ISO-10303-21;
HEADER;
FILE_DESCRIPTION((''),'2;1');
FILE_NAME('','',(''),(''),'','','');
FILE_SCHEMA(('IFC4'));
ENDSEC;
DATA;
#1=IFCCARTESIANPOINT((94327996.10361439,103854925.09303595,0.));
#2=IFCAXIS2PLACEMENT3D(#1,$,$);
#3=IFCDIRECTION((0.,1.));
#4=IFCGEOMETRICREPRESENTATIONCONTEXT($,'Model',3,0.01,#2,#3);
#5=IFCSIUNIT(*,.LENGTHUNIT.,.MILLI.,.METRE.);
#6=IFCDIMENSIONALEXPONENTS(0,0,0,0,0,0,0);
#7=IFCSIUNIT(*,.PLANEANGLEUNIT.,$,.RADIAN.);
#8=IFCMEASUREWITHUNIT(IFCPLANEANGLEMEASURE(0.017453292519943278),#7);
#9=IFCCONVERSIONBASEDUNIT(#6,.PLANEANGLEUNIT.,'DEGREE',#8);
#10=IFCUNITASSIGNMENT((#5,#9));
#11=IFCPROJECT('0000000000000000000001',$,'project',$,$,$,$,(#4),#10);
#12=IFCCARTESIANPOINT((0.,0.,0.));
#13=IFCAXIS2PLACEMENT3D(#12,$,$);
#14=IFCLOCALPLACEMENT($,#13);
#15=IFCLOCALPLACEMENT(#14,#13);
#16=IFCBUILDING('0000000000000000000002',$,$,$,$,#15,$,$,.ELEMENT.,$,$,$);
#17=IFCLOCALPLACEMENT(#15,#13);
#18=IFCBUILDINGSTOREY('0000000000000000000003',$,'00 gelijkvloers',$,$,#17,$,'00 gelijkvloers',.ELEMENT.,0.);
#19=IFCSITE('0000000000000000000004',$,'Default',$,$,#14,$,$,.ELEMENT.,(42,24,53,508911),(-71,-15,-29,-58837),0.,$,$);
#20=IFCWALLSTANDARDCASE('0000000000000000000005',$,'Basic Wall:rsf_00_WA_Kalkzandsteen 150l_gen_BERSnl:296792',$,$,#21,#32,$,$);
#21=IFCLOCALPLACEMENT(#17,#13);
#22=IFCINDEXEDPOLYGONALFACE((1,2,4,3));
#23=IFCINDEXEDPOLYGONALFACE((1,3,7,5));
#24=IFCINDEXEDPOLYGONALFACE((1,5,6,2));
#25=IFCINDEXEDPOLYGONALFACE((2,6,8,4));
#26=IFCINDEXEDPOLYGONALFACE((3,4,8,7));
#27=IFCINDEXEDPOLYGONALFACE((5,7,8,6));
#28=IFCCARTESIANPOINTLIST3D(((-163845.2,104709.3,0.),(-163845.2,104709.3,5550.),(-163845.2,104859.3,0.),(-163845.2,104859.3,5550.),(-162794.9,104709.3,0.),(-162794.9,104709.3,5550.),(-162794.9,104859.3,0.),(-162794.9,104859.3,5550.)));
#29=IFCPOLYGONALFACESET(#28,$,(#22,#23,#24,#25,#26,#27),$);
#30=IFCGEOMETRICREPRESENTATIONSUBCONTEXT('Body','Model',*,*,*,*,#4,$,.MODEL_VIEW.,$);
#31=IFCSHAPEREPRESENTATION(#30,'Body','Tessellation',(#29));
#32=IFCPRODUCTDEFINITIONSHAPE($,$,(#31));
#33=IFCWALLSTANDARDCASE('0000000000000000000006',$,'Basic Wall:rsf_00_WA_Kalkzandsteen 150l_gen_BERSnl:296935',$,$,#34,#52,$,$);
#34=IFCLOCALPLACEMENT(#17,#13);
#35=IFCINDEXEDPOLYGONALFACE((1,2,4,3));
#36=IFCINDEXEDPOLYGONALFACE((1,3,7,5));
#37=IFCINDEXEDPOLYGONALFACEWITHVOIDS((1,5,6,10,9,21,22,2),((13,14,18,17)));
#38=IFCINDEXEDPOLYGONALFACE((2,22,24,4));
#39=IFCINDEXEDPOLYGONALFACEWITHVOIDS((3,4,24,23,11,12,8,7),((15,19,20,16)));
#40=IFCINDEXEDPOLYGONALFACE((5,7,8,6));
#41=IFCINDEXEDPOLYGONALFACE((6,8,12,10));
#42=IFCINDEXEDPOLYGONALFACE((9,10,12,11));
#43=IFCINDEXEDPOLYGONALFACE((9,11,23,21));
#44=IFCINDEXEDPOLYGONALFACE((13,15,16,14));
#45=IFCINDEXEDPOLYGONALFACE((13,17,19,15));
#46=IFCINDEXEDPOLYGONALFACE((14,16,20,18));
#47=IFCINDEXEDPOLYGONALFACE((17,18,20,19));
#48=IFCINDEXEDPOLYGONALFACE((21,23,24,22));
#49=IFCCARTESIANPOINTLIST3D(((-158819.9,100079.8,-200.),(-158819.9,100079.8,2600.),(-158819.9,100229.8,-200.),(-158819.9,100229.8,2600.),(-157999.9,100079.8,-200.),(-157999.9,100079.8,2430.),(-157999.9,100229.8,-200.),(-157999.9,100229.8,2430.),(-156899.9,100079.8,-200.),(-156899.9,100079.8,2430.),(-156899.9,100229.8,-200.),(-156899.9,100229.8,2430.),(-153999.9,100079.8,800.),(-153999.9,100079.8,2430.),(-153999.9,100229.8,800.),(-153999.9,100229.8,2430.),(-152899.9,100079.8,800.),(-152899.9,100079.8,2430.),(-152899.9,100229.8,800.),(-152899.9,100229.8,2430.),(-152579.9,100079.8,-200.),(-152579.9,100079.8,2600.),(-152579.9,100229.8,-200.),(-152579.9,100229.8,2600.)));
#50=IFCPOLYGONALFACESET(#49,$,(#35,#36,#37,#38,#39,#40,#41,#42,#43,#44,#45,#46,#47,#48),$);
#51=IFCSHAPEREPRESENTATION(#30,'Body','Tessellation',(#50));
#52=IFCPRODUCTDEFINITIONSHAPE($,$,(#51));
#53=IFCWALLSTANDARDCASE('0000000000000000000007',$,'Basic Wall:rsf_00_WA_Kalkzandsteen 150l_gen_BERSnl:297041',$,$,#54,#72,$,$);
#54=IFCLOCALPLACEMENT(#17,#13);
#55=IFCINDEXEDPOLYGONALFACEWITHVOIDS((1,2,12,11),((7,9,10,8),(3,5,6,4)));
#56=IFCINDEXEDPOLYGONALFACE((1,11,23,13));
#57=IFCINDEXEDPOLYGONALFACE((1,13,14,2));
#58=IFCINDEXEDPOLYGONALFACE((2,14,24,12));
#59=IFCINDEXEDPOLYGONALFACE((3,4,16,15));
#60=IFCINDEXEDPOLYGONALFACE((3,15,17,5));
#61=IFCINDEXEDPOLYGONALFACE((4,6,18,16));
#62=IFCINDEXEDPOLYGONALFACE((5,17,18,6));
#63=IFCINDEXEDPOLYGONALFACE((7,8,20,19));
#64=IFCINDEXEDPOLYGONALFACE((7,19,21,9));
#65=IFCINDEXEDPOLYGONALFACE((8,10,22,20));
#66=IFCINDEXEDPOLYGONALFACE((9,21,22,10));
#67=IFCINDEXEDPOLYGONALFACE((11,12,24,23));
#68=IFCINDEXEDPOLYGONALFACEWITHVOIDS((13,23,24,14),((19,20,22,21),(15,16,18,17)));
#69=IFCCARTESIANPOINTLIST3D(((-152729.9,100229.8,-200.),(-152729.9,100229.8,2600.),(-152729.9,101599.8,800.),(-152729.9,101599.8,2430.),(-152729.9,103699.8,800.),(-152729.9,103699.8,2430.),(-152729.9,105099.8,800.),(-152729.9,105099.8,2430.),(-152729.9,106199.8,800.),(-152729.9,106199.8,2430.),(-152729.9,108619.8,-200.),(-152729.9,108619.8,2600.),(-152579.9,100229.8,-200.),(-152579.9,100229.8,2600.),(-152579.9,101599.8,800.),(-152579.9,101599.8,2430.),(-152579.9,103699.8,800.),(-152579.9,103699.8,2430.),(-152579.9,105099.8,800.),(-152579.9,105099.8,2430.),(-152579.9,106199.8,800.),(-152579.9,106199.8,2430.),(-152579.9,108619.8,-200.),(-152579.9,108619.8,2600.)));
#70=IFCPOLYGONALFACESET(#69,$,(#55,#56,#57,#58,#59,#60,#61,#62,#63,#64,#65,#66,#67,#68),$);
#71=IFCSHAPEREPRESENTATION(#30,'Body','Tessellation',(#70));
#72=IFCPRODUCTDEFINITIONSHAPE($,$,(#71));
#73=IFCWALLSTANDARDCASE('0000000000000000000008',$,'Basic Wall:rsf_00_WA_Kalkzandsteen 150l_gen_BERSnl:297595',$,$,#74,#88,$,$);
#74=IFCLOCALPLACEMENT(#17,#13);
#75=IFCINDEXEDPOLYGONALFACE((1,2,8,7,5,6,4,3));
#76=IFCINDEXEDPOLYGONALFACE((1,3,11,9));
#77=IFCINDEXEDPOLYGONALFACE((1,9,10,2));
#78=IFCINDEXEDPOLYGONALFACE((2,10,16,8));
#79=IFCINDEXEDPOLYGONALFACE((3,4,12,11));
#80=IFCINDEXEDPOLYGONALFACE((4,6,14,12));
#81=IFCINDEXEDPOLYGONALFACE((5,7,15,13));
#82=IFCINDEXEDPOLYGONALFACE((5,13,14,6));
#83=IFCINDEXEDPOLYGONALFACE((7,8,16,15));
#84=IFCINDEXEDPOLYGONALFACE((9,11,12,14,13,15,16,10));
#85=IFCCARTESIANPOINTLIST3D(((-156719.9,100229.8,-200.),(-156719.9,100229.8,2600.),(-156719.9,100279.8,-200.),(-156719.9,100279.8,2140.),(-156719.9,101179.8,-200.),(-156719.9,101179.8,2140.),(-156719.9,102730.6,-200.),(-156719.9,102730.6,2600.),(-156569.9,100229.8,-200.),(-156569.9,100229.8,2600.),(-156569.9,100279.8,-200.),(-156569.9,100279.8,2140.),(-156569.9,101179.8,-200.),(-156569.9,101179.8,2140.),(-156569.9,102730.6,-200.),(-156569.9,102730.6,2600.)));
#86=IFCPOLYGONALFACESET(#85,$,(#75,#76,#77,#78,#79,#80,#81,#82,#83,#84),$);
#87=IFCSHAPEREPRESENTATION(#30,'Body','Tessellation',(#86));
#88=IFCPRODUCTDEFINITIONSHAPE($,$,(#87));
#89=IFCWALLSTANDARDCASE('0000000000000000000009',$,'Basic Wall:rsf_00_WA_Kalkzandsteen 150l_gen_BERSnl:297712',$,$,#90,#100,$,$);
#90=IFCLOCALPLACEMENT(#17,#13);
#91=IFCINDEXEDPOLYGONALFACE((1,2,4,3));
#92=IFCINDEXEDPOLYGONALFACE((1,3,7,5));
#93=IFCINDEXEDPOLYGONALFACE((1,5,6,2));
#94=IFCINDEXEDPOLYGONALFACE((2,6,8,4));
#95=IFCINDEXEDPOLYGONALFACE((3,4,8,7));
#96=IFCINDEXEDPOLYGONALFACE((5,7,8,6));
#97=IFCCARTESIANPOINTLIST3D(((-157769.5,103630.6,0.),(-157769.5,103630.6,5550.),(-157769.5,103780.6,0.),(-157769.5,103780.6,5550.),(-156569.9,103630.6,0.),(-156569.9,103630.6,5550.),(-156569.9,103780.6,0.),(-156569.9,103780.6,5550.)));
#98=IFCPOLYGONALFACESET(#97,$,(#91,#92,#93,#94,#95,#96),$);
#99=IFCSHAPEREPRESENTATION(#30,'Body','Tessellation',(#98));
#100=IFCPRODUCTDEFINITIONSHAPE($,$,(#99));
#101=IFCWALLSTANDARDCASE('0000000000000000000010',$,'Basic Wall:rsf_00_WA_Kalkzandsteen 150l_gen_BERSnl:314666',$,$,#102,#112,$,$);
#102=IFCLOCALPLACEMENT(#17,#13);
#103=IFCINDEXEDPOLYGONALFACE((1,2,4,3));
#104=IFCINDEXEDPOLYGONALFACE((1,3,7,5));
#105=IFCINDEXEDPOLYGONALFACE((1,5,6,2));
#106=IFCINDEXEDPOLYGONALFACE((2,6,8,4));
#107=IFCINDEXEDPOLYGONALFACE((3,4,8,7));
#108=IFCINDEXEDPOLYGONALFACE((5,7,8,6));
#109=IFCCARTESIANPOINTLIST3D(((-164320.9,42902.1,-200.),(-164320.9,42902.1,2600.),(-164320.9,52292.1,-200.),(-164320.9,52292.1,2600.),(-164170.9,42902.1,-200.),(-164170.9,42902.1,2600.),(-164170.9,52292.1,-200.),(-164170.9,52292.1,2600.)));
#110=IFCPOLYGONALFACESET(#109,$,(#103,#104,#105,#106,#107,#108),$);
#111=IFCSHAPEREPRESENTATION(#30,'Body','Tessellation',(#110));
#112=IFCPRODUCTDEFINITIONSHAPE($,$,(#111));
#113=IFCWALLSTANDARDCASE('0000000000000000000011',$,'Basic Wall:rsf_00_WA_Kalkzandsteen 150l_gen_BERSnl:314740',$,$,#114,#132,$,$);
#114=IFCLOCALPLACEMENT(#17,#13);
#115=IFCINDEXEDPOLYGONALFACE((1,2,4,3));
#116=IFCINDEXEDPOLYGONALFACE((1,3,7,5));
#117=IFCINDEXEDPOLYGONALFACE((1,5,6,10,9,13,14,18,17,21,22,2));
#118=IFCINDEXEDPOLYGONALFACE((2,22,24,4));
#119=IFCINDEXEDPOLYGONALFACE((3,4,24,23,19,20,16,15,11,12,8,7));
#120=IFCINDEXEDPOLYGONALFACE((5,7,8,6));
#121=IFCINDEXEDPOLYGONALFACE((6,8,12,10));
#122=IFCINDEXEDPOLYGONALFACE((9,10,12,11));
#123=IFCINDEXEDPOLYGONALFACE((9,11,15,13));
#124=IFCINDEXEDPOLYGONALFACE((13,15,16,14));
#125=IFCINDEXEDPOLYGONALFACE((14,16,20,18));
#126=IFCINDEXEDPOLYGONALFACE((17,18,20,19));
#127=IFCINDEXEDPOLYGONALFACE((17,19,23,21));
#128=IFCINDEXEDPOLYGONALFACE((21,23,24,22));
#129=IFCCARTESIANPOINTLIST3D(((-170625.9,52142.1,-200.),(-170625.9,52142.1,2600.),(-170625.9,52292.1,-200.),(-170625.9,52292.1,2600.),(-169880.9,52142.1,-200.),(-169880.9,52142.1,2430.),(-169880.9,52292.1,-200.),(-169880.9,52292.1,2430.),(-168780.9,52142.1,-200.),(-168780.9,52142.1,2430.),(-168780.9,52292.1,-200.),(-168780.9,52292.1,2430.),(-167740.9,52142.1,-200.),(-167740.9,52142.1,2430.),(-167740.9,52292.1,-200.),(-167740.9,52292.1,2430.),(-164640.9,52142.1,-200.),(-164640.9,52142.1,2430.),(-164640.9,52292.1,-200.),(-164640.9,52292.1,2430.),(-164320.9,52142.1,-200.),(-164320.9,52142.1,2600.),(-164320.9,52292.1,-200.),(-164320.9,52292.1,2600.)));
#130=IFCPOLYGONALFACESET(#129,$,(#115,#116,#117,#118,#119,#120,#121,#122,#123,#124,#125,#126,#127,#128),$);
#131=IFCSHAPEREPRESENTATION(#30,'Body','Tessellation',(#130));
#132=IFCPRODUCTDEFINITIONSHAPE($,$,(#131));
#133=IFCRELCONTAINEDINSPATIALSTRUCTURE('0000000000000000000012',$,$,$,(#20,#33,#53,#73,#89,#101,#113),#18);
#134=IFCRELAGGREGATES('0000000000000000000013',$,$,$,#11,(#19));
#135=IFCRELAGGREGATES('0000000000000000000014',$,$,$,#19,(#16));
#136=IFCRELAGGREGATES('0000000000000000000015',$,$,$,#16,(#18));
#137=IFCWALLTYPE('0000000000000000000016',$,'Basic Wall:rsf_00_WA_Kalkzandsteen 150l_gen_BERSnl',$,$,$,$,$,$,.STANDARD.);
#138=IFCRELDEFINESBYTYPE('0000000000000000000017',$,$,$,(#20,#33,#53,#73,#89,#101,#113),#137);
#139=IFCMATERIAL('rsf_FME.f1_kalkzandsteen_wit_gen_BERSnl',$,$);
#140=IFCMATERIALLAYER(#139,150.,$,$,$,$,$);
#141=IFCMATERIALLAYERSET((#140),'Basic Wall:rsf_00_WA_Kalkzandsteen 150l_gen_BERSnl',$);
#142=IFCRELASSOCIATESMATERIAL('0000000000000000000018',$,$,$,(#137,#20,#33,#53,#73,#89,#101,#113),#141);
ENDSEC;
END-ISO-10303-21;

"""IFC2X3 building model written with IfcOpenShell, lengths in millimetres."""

from ifc_helpers import new_model, entity, si_unit, converted_unit, direction, frame, frame_2d, origin, origin_2d_with_axis, place, context, subcontext, project, spatial, polyline, rectangle, extrude, clip, bounded_halfspace, material, layer, layer_set, layer_usage, type_object, element, save


model = new_model("IFC2X3")

# Units and contexts
model_context = context("Model", 3, precision=0.01, world=frame((94327996.10361439, 103854925.09303595, 0.0)), true_north=direction((0.0, 1.0)))
body_context = subcontext(model_context, "Body", "Model", "MODEL_VIEW")
ifc_project = project(units=[si_unit("LENGTHUNIT", "METRE", prefix="MILLI"), converted_unit("PLANEANGLEUNIT", "DEGREE", entity("IfcPlaneAngleMeasure", 0.017453292519943278), si_unit("PLANEANGLEUNIT", "RADIAN"), dimensions=[0, 0, 0, 0, 0, 0, 0])], contexts=[model_context])

# Site, building, storey
site_placement = place(None, origin())
site = spatial("IfcSite", under=ifc_project, at=site_placement, Name="Default", CompositionType="ELEMENT", RefLatitude=(42, 24, 53, 508911), RefLongitude=(-71, -15, -29, -58837), RefElevation=0.0)
building_placement = place(site_placement, origin())
building = spatial("IfcBuilding", under=site, at=building_placement, CompositionType="ELEMENT")
storey_placement = place(building_placement, origin())
storey = spatial("IfcBuildingStorey", under=building, at=storey_placement, Name="00 gelijkvloers", LongName="00 gelijkvloers", CompositionType="ELEMENT", Elevation=0.0)

# Shared definitions
ifc_material_1 = material(Name="rsf_FME.f1_kalkzandsteen_wit_gen_BERSnl")
ifc_layer_1 = layer(ifc_material_1, 150.0)
ifc_layer_set_1 = layer_set([ifc_layer_1], Name="Basic Wall:rsf_00_WA_Kalkzandsteen 150l_gen_BERSnl")
wall_type_1 = type_object("IfcWallType", Name="Basic Wall:rsf_00_WA_Kalkzandsteen 150l_gen_BERSnl", PredefinedType="STANDARD", material=ifc_layer_set_1)

# Wall
ifc_layer_usage_1 = layer_usage(ifc_layer_set_1, "AXIS2", "NEGATIVE", 75.0)
wall_1_placement = place(storey_placement, frame((-162794.9, 104784.3, 0.0), z_axis=(0.0, 0.0, 1.0), x_axis=(-1.0, 0.0, 0.0)))
element("IfcWallStandardCase", 1, at=wall_1_placement, inside=storey, type_object=wall_type_1, material=ifc_layer_usage_1, Name="Basic Wall:rsf_00_WA_Kalkzandsteen 150l_gen_BERSnl:296792", context=body_context, shape_type="Clipping", body=[
    clip(extrude(rectangle(XDim=1050.4, YDim=150.0, at=frame_2d((525.2, 0.0), x_axis=(-1.0, 0.0))), origin(), (0.0, 0.0, 1.0), 5550.0), bounded_halfspace(frame((0.0, -75.0, 5550.0), z_axis=(0.0, 0.0, -1.0), x_axis=(0.0, -1.0, 0.0)), True, frame((0.0, -75.0, 5550.0)), polyline([(0.0, 0.0), (1050.4, 0.0), (1050.4, 150.0), (0.0, 150.0), (0.0, 0.0)]))),
])

# Walls, openings
ifc_layer_usage_2 = layer_usage(ifc_layer_set_1, "AXIS2", "NEGATIVE", 75.0)
wall_2_placement = place(storey_placement, frame((-158819.9, 100154.8, -200.0)))
wall_2 = element("IfcWallStandardCase", 2, at=wall_2_placement, inside=storey, type_object=wall_type_1, material=ifc_layer_usage_2, Name="Basic Wall:rsf_00_WA_Kalkzandsteen 150l_gen_BERSnl:296935", context=body_context, shape_type="Clipping", body=[
    clip(extrude(rectangle(XDim=6240.0, YDim=150.0, at=frame_2d((3120.0, 0.0), x_axis=(1.0, 0.0))), origin(), (0.0, 0.0, 1.0), 2800.0), bounded_halfspace(frame((0.0, -75.0, 2800.0), z_axis=(0.0, 0.0, -1.0), x_axis=(0.0, 1.0, 0.0)), True, frame((0.0, -75.0, 2800.0)), polyline([(0.0, 0.0), (6240.0, 0.0), (6240.0, 150.0), (6090.0, 150.0), (2250.0, 150.0), (2100.0, 150.0), (150.0, 150.0), (0.0, 150.0), (0.0, 0.0)]))),
])
opening_1_placement = place(wall_2_placement, frame((158819.9, -100154.8, 200.0)))
element("IfcOpeningElement", 3, at=opening_1_placement, cuts=wall_2, ObjectType="Opening", context=body_context, shape_type="SweptSolid", body=[
    extrude(rectangle(XDim=2630.0, YDim=1100.0, at=frame_2d((0.0, 0.0), x_axis=(0.0, 1.0))), frame((-157449.9, 98555.8, 1115.0), z_axis=(0.0, 1.0, 0.0), x_axis=(-1.0, 0.0, 0.0)), (0.0, 0.0, 1.0), 3048.0),
])
opening_2_placement = place(wall_2_placement, frame((158819.9, -100154.8, 200.0)))
element("IfcOpeningElement", 4, at=opening_2_placement, cuts=wall_2, ObjectType="Opening", context=body_context, shape_type="SweptSolid", body=[
    extrude(rectangle(XDim=1630.0, YDim=1100.0, at=origin_2d_with_axis()), frame((-153449.9, 98705.8, 1615.0), z_axis=(0.0, 1.0, 0.0), x_axis=(0.0, 0.0, 1.0)), (0.0, 0.0, 1.0), 3048.0),
])
ifc_layer_usage_3 = layer_usage(ifc_layer_set_1, "AXIS2", "NEGATIVE", 75.0)
wall_3_placement = place(storey_placement, frame((-152654.9, 100229.8, -200.0), z_axis=(0.0, 0.0, 1.0), x_axis=(0.0, 1.0, 0.0)))
wall_3 = element("IfcWallStandardCase", 5, at=wall_3_placement, inside=storey, type_object=wall_type_1, material=ifc_layer_usage_3, Name="Basic Wall:rsf_00_WA_Kalkzandsteen 150l_gen_BERSnl:297041", context=body_context, shape_type="Clipping", body=[
    clip(extrude(rectangle(XDim=8390.0, YDim=150.0, at=frame_2d((4195.0, 0.0), x_axis=(-1.0, 0.0))), origin(), (0.0, 0.0, 1.0), 2800.0), bounded_halfspace(frame((0.0, -75.0, 2800.0), z_axis=(0.0, 0.0, -1.0), x_axis=(1.0, 0.0, 0.0)), True, frame((0.0, -75.0, 2800.0)), polyline([(0.0, 0.0), (8390.0, 0.0), (8390.0, 150.0), (8240.0, 150.0), (0.0, 150.0), (0.0, 0.0)]))),
])
opening_3_placement = place(wall_3_placement, frame((-100229.8, -152654.9, 200.0), z_axis=(0.0, 0.0, 1.0), x_axis=(0.0, -1.0, 0.0)))
element("IfcOpeningElement", 6, at=opening_3_placement, cuts=wall_3, ObjectType="Opening", context=body_context, shape_type="SweptSolid", body=[
    extrude(rectangle(XDim=1630.0, YDim=1100.0, at=origin_2d_with_axis()), frame((-151205.9, 105649.8, 1615.0), z_axis=(-1.0, 0.0, 0.0), x_axis=(0.0, 0.0, 1.0)), (0.0, 0.0, 1.0), 3048.0),
])
opening_4_placement = place(wall_3_placement, frame((-100229.8, -152654.9, 200.0), z_axis=(0.0, 0.0, 1.0), x_axis=(0.0, -1.0, 0.0)))
element("IfcOpeningElement", 7, at=opening_4_placement, cuts=wall_3, ObjectType="Opening", context=body_context, shape_type="SweptSolid", body=[
    extrude(rectangle(XDim=1630.0, YDim=2100.0, at=frame_2d((0.0, 0.0), x_axis=(0.0, 1.0))), frame((-151055.9, 102649.8, 1615.0), z_axis=(-1.0, 0.0, 0.0), x_axis=(0.0, -1.0, 0.0)), (0.0, 0.0, 1.0), 3048.0),
])

# Wall, opening
ifc_layer_usage_4 = layer_usage(ifc_layer_set_1, "AXIS2", "POSITIVE", -75.0)
wall_4_placement = place(storey_placement, frame((-156644.9, 100229.8, -200.0), z_axis=(0.0, 0.0, 1.0), x_axis=(0.0, 1.0, 0.0)))
wall_4 = element("IfcWallStandardCase", 8, at=wall_4_placement, inside=storey, type_object=wall_type_1, material=ifc_layer_usage_4, Name="Basic Wall:rsf_00_WA_Kalkzandsteen 150l_gen_BERSnl:297595", context=body_context, shape_type="Clipping", body=[
    clip(extrude(rectangle(XDim=2500.8, YDim=150.0, at=frame_2d((1250.4, 0.0), x_axis=(1.0, 0.0))), origin(), (0.0, 0.0, 1.0), 2800.0), bounded_halfspace(frame((0.0, -75.0, 2800.0), z_axis=(0.0, 0.0, -1.0), x_axis=(1.0, 0.0, 0.0)), True, frame((0.0, -75.0, 2800.0)), polyline([(0.0, 0.0), (2500.8, 0.0), (2500.8, 150.0), (0.0, 150.0), (0.0, 0.0)]))),
])
opening_5_placement = place(wall_4_placement, frame((-100229.8, -156644.9, 200.0), z_axis=(0.0, 0.0, 1.0), x_axis=(0.0, -1.0, 0.0)))
element("IfcOpeningElement", 9, at=opening_5_placement, cuts=wall_4, ObjectType="Opening", context=body_context, shape_type="SweptSolid", body=[
    extrude(rectangle(XDim=2340.0, YDim=900.0, at=origin_2d_with_axis()), frame((-155195.9, 100729.8, 970.0), z_axis=(-1.0, 0.0, 0.0), x_axis=(0.0, 0.0, 1.0)), (0.0, 0.0, 1.0), 3048.0),
])

# Walls
ifc_layer_usage_5 = layer_usage(ifc_layer_set_1, "AXIS2", "NEGATIVE", 75.0)
wall_5_placement = place(storey_placement, frame((-156569.9, 103705.6, 0.0), z_axis=(0.0, 0.0, 1.0), x_axis=(-1.0, 0.0, 0.0)))
element("IfcWallStandardCase", 10, at=wall_5_placement, inside=storey, type_object=wall_type_1, material=ifc_layer_usage_5, Name="Basic Wall:rsf_00_WA_Kalkzandsteen 150l_gen_BERSnl:297712", context=body_context, shape_type="Clipping", body=[
    clip(extrude(rectangle(XDim=1199.6, YDim=150.0, at=frame_2d((599.8, 0.0), x_axis=(-1.0, 0.0))), origin(), (0.0, 0.0, 1.0), 5550.0), bounded_halfspace(frame((0.0, -75.0, 5550.0), z_axis=(0.0, 0.0, -1.0), x_axis=(0.0, -1.0, 0.0)), True, frame((0.0, -75.0, 5550.0)), polyline([(0.0, 0.0), (1199.6, 0.0), (1199.6, 150.0), (0.0, 150.0), (0.0, 0.0)]))),
])
ifc_layer_usage_6 = layer_usage(ifc_layer_set_1, "AXIS2", "NEGATIVE", 75.0)
wall_6_placement = place(storey_placement, frame((-164245.9, 42902.1, -200.0), z_axis=(0.0, 0.0, 1.0), x_axis=(0.0, 1.0, 0.0)))
element("IfcWallStandardCase", 11, at=wall_6_placement, inside=storey, type_object=wall_type_1, material=ifc_layer_usage_6, Name="Basic Wall:rsf_00_WA_Kalkzandsteen 150l_gen_BERSnl:314666", context=body_context, shape_type="Clipping", body=[
    clip(extrude(rectangle(XDim=9390.0, YDim=150.0, at=frame_2d((4695.0, 0.0), x_axis=(-1.0, 0.0))), origin(), (0.0, 0.0, 1.0), 2800.0), bounded_halfspace(frame((0.0, -75.0, 2800.0), z_axis=(0.0, 0.0, -1.0), x_axis=(0.0, -1.0, 0.0)), True, frame((0.0, -75.0, 2800.0)), polyline([(0.0, 0.0), (9390.0, 0.0), (9390.0, 150.0), (9240.0, 150.0), (0.0, 150.0), (0.0, 0.0)]))),
])

# Wall, openings
ifc_layer_usage_7 = layer_usage(ifc_layer_set_1, "AXIS2", "NEGATIVE", 75.0)
wall_7_placement = place(storey_placement, frame((-164320.9, 52217.1, -200.0), z_axis=(0.0, 0.0, 1.0), x_axis=(-1.0, 0.0, 0.0)))
wall_7 = element("IfcWallStandardCase", 12, at=wall_7_placement, inside=storey, type_object=wall_type_1, material=ifc_layer_usage_7, Name="Basic Wall:rsf_00_WA_Kalkzandsteen 150l_gen_BERSnl:314740", context=body_context, shape_type="Clipping", body=[
    clip(extrude(rectangle(XDim=6305.0, YDim=150.0, at=frame_2d((3152.5, 0.0), x_axis=(-1.0, 0.0))), origin(), (0.0, 0.0, 1.0), 2800.0), bounded_halfspace(frame((0.0, -75.0, 2800.0), z_axis=(0.0, 0.0, -1.0), x_axis=(-1.0, 0.0, 0.0)), True, frame((0.0, -75.0, 2800.0)), polyline([(0.0, 0.0), (6305.0, 0.0), (6305.0, 150.0), (6155.0, 150.0), (0.0, 150.0), (0.0, 0.0)]))),
])
opening_6_placement = place(wall_7_placement, frame((-164320.9, 52217.1, 200.0), z_axis=(0.0, 0.0, 1.0), x_axis=(-1.0, 0.0, 0.0)))
element("IfcOpeningElement", 13, at=opening_6_placement, cuts=wall_7, ObjectType="Opening", context=body_context, shape_type="SweptSolid", body=[
    extrude(rectangle(XDim=2630.0, YDim=3100.0, at=frame_2d((0.0, 0.0), x_axis=(0.0, 1.0))), frame((-166190.9, 53816.1, 1115.0), z_axis=(0.0, -1.0, 0.0), x_axis=(1.0, 0.0, 0.0)), (0.0, 0.0, 1.0), 3048.0),
])
opening_7_placement = place(wall_7_placement, frame((-164320.9, 52217.1, 200.0), z_axis=(0.0, 0.0, 1.0), x_axis=(-1.0, 0.0, 0.0)))
element("IfcOpeningElement", 14, at=opening_7_placement, cuts=wall_7, ObjectType="Opening", context=body_context, shape_type="SweptSolid", body=[
    extrude(rectangle(XDim=2630.0, YDim=1100.0, at=frame_2d((0.0, 0.0), x_axis=(0.0, 1.0))), frame((-169330.9, 53816.1, 1115.0), z_axis=(0.0, -1.0, 0.0), x_axis=(1.0, 0.0, 0.0)), (0.0, 0.0, 1.0), 3048.0),
])

save(model, "model.ifc")
